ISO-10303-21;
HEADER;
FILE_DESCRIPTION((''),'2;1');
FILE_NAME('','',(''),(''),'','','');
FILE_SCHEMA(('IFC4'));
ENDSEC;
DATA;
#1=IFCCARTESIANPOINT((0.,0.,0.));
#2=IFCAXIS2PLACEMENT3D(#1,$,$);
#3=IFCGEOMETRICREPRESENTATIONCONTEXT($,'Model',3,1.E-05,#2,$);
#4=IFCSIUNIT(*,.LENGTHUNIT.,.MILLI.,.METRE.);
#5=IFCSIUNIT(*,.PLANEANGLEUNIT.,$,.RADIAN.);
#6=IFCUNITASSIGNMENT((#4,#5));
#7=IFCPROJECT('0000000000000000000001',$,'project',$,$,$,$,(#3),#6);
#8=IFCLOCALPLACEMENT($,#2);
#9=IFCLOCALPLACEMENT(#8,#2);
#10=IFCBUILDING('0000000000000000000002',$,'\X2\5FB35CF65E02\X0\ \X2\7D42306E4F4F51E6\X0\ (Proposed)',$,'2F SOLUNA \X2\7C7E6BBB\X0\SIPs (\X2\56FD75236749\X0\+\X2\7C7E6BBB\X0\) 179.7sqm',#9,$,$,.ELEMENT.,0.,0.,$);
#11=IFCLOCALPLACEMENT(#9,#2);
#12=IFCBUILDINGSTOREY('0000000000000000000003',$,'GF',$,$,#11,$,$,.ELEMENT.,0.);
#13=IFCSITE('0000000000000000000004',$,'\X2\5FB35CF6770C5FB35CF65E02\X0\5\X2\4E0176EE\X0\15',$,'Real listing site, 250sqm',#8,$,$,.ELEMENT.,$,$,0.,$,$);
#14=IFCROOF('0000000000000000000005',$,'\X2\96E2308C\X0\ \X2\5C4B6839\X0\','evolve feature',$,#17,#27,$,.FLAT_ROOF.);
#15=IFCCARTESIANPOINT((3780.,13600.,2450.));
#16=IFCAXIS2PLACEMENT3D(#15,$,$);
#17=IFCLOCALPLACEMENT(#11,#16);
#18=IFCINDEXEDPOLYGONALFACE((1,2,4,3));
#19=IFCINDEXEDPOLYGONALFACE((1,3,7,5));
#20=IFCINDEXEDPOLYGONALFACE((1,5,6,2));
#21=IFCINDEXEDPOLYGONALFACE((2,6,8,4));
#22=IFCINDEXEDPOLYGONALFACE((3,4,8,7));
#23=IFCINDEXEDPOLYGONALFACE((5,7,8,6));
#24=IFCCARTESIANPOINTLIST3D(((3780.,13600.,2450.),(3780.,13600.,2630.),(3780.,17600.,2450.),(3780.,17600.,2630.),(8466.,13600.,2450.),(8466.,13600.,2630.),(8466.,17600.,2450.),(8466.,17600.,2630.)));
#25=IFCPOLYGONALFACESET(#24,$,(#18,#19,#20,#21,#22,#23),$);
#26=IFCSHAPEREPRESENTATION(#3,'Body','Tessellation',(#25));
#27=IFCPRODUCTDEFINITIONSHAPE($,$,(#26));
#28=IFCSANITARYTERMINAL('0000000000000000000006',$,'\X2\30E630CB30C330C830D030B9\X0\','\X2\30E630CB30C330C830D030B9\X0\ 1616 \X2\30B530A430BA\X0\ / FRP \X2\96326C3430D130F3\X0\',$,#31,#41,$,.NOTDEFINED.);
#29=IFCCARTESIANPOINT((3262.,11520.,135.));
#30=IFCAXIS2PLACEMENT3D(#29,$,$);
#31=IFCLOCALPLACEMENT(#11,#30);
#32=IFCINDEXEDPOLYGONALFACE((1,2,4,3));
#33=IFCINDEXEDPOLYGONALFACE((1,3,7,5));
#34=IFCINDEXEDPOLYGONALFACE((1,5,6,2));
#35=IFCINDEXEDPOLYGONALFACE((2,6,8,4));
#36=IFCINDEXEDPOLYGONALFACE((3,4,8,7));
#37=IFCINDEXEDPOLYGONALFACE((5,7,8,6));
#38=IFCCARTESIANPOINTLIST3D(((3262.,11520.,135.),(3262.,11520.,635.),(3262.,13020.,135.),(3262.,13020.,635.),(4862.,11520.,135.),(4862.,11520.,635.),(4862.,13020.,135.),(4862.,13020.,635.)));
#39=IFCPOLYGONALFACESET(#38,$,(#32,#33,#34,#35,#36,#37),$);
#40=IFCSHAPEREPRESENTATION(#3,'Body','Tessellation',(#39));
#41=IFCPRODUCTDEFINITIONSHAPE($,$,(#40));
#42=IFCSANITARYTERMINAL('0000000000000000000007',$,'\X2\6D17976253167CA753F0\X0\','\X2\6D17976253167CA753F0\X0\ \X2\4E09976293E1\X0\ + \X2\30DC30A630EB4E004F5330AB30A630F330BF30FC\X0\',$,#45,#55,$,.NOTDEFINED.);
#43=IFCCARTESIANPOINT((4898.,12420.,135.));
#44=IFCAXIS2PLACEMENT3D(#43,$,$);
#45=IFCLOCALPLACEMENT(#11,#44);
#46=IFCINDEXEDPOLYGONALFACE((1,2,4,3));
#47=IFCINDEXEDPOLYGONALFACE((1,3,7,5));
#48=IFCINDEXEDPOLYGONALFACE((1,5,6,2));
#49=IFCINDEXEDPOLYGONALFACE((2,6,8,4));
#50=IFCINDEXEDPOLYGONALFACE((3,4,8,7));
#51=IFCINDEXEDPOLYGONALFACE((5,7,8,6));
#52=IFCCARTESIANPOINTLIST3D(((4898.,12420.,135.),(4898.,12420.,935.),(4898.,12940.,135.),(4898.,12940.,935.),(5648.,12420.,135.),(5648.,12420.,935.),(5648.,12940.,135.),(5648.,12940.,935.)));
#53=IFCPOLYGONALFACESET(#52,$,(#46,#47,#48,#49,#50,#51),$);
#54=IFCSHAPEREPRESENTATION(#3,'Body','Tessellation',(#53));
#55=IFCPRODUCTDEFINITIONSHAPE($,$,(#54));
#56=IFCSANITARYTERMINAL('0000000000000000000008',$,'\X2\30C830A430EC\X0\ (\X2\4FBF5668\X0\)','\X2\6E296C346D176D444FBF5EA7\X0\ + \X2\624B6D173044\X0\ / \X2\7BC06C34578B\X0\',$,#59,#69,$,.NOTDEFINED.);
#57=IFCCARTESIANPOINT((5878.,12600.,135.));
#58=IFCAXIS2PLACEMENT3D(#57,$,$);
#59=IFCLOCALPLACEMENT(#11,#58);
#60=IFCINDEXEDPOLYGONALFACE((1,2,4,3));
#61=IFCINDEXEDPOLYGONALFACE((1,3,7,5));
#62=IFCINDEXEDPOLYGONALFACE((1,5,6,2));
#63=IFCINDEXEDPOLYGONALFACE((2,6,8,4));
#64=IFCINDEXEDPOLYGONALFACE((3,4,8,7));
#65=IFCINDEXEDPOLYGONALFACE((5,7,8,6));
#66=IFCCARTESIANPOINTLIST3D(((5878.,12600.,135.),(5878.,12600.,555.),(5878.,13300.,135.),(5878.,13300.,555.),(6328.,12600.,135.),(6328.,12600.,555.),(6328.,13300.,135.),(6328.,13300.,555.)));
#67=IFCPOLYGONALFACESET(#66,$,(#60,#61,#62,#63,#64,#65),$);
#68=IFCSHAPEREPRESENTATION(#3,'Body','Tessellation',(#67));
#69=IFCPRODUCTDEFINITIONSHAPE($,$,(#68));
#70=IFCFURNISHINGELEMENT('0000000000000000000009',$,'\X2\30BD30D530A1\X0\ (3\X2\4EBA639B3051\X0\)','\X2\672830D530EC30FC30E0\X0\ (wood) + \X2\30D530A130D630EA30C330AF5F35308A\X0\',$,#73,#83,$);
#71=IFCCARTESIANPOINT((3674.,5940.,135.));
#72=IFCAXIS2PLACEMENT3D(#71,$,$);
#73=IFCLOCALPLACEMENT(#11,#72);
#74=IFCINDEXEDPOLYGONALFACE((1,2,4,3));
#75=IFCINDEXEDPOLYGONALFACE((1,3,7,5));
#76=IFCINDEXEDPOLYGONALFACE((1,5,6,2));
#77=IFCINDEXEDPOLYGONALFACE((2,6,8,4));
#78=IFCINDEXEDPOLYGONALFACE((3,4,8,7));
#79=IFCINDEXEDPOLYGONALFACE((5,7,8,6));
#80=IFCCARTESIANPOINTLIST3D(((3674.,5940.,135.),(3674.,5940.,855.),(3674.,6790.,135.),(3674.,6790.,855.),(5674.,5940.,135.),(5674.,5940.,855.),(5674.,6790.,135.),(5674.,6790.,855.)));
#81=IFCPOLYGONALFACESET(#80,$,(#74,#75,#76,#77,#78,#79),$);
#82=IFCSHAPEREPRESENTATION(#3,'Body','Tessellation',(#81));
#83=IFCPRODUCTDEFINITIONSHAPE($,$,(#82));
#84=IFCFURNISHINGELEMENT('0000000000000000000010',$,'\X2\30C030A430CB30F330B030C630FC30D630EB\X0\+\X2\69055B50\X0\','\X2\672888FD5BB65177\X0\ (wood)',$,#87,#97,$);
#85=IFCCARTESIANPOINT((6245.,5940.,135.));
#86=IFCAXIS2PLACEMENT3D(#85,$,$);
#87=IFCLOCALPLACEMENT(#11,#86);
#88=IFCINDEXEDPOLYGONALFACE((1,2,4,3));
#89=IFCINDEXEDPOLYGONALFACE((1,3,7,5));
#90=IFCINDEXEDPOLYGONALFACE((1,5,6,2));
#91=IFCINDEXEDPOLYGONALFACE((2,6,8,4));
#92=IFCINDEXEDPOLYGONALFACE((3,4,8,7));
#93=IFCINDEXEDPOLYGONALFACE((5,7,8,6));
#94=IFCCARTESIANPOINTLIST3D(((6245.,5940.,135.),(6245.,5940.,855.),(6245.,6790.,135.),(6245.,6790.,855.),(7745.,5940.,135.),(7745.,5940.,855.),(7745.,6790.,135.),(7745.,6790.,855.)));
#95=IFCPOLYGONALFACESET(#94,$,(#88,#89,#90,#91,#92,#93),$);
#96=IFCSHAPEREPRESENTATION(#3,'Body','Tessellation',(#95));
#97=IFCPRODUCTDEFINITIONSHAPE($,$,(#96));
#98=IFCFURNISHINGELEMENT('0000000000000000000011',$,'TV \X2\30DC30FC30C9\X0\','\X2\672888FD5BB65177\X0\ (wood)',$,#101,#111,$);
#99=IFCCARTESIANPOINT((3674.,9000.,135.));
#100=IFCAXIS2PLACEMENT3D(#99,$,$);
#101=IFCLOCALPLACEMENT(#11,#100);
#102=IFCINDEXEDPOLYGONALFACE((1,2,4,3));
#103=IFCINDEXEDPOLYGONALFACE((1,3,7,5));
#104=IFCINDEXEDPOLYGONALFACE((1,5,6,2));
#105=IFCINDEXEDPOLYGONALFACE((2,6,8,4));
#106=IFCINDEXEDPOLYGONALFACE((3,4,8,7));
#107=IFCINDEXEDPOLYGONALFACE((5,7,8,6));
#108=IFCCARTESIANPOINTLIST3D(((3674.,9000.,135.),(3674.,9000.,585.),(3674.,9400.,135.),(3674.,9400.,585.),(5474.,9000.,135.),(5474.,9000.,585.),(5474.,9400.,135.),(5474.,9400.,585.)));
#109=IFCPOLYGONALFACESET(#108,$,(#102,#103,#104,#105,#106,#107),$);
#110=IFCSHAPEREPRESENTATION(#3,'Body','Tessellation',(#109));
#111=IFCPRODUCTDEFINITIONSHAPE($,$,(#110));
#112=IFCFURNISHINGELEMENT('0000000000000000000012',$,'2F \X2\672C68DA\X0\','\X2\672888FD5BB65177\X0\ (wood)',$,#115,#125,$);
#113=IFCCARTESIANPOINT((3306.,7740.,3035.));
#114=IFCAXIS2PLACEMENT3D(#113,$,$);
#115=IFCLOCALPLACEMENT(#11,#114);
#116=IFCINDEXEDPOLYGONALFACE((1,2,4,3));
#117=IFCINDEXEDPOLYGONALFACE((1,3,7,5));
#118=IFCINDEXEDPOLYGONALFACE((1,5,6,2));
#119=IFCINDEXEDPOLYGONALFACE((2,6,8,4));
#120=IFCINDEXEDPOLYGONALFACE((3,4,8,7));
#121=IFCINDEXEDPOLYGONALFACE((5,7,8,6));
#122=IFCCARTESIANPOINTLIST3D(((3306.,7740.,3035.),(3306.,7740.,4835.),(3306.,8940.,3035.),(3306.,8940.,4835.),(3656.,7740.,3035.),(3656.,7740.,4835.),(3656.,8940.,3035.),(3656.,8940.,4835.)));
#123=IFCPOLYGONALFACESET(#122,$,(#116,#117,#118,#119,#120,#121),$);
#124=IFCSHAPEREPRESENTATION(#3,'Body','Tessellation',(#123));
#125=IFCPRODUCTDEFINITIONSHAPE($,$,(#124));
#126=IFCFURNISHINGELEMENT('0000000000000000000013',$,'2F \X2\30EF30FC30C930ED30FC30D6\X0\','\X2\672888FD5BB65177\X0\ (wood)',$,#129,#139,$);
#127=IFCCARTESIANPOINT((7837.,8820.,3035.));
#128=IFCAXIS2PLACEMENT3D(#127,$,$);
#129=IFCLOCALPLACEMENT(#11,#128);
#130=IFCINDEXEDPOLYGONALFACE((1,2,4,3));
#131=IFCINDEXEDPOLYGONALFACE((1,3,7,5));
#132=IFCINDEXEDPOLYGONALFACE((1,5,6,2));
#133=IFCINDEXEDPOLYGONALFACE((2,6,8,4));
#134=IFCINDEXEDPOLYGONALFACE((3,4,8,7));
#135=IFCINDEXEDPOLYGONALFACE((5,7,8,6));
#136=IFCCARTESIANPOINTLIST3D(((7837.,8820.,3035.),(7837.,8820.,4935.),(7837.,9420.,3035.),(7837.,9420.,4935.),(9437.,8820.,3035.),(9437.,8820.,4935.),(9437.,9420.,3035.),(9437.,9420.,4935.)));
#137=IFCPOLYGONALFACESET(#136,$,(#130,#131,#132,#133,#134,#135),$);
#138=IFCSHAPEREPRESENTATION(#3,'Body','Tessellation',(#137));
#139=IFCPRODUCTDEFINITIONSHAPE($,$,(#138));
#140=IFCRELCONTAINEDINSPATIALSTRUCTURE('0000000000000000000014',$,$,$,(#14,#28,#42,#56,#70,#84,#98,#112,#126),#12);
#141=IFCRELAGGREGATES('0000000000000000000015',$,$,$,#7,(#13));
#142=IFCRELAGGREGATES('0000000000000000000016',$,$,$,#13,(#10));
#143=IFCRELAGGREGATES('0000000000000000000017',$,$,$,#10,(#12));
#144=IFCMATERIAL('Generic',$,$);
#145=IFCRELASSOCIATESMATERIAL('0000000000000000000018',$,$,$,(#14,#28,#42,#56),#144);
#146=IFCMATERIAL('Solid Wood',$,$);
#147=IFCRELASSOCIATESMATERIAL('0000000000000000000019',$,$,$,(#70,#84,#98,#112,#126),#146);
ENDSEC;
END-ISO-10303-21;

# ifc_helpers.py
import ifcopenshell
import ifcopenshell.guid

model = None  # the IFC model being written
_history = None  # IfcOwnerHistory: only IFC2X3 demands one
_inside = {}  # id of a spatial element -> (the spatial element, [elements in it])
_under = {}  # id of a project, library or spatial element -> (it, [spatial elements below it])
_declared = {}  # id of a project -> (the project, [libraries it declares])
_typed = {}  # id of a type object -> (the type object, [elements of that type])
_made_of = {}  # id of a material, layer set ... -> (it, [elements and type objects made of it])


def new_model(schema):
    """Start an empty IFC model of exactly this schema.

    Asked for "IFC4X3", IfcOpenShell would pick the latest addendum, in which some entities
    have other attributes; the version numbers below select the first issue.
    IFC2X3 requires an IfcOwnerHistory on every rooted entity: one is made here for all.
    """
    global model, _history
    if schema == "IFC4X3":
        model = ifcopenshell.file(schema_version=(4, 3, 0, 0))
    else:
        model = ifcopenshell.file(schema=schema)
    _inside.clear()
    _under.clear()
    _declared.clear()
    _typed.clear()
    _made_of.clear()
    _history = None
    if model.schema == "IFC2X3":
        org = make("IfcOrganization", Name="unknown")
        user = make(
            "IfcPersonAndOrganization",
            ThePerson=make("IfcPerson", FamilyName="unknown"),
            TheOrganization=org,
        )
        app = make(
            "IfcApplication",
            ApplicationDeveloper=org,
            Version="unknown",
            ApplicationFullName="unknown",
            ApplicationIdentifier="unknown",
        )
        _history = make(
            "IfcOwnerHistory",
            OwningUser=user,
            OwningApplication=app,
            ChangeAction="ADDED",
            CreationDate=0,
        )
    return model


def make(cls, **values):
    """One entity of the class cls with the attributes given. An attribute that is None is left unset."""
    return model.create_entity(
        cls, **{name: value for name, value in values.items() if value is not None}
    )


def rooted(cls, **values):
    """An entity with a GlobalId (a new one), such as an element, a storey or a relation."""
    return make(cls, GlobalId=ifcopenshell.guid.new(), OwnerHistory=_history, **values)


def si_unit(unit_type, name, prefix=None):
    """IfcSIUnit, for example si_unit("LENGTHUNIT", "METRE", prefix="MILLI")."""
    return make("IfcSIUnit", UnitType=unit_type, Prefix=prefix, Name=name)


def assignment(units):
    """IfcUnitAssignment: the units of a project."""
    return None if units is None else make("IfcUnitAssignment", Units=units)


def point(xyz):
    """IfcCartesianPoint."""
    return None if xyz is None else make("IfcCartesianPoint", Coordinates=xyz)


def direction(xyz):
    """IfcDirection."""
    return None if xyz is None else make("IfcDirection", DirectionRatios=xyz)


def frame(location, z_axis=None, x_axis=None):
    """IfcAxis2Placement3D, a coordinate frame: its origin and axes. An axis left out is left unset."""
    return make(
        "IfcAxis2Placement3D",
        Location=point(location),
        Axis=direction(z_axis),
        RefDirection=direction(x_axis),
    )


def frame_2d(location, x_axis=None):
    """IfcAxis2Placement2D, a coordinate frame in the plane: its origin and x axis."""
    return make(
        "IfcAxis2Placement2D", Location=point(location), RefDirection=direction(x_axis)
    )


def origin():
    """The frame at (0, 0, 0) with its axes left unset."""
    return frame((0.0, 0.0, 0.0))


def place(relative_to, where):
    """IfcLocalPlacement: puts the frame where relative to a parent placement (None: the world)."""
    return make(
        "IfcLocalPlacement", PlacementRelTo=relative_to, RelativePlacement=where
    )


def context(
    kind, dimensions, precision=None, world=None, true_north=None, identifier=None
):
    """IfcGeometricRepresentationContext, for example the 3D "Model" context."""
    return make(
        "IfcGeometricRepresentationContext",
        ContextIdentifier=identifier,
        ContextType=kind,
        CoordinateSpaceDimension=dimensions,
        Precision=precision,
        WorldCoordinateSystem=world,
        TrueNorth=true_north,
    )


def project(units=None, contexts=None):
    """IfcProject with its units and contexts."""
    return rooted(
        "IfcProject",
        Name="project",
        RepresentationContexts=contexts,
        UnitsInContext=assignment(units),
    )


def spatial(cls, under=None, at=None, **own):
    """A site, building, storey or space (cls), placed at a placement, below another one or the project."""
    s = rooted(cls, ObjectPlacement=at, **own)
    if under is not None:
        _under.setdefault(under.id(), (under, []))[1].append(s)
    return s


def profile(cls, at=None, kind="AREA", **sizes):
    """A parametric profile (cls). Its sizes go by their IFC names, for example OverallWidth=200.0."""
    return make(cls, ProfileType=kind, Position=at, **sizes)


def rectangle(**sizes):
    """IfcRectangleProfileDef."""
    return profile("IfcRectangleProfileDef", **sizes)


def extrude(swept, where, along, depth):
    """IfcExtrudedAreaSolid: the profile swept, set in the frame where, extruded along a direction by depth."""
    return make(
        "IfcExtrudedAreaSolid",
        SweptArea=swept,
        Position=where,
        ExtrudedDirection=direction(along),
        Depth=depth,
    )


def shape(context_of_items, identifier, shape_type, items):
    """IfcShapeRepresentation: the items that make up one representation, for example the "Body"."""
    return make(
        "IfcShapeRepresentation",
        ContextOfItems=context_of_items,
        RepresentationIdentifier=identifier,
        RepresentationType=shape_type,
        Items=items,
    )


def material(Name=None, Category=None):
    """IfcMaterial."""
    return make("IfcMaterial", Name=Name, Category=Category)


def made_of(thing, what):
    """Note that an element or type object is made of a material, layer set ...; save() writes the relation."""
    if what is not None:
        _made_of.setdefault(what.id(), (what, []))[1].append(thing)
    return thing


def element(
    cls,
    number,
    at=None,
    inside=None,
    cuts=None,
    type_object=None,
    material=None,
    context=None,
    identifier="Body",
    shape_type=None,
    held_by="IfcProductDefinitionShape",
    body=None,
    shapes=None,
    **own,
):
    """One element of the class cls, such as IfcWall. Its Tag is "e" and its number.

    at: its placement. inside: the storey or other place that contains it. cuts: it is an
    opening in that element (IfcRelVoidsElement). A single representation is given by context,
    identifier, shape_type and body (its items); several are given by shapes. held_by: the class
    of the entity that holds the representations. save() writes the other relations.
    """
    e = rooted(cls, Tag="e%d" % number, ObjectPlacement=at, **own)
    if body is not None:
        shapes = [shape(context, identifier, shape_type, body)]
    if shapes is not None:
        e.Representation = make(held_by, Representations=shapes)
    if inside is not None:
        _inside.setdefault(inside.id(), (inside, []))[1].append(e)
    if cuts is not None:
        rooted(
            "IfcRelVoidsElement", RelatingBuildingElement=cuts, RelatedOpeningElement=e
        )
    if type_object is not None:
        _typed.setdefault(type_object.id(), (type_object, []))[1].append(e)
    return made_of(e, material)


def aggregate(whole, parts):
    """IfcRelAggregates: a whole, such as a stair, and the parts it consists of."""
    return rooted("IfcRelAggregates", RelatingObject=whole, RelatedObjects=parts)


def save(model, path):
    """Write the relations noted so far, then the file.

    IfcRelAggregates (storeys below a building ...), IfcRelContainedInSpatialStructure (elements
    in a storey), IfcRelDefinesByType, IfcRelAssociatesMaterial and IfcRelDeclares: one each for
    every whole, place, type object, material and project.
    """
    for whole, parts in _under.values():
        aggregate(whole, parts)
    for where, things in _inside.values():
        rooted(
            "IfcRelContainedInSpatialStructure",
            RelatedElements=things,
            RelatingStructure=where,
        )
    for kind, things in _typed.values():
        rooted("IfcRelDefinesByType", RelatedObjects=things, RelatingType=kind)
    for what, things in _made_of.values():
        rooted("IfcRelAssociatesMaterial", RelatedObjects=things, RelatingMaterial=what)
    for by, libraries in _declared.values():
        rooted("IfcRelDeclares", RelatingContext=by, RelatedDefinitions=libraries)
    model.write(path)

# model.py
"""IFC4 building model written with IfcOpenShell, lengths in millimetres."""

from ifc_helpers import new_model, si_unit, frame, frame_2d, origin, place, context, project, spatial, rectangle, extrude, material, element, save


model = new_model("IFC4")

# Units and contexts
model_context = context("Model", 3, precision=1e-05, world=origin())
ifc_project = project(units=[si_unit("LENGTHUNIT", "METRE", prefix="MILLI"), si_unit("PLANEANGLEUNIT", "RADIAN")], contexts=[model_context])

# Site, building, storey
site_placement = place(None, origin())
site = spatial("IfcSite", under=ifc_project, at=site_placement, Name="徳島県徳島市5丁目15", ObjectType="Real listing site, 250sqm", CompositionType="ELEMENT", RefElevation=0.0)
building_placement = place(site_placement, origin())
building = spatial("IfcBuilding", under=site, at=building_placement, Name="徳島市 終の住処 (Proposed)", ObjectType="2F SOLUNA 籾殻SIPs (国産杉+籾殻) 179.7sqm", CompositionType="ELEMENT", ElevationOfRefHeight=0.0, ElevationOfTerrain=0.0)
storey_placement = place(building_placement, origin())
storey = spatial("IfcBuildingStorey", under=building, at=storey_placement, Name="GF", CompositionType="ELEMENT", Elevation=0.0)

# Shared definitions
ifc_material_1 = material(Name="Generic")

# Shared definitions
ifc_material_2 = material(Name="Solid Wood")

# Roof
roof_1_placement = place(storey_placement, frame((3780.0, 13600.0, 2450.0)))
element("IfcRoof", 1, at=roof_1_placement, inside=storey, material=ifc_material_1, Name="離れ 屋根", Description="evolve feature", PredefinedType="FLAT_ROOF", context=model_context, shape_type="SweptSolid", body=[
    extrude(rectangle(XDim=4686.0, YDim=4000.0, at=frame_2d((2343.0, 2000.0))), frame((3780.0, 13600.0, 2450.0)), (0.0, 0.0, 1.0), 180.0),
])

# Sanitary terminals
sanitary_terminal_1_placement = place(storey_placement, frame((3262.0, 11520.0, 135.0)))
element("IfcSanitaryTerminal", 2, at=sanitary_terminal_1_placement, inside=storey, material=ifc_material_1, Name="ユニットバス", Description="ユニットバス 1616 サイズ / FRP 防水パン", PredefinedType="NOTDEFINED", context=model_context, shape_type="SweptSolid", body=[
    extrude(rectangle(XDim=1600.0, YDim=1500.0, at=frame_2d((800.0, 750.0))), frame((3262.0, 11520.0, 135.0)), (0.0, 0.0, 1.0), 500.0),
])
sanitary_terminal_2_placement = place(storey_placement, frame((4898.0, 12420.0, 135.0)))
element("IfcSanitaryTerminal", 3, at=sanitary_terminal_2_placement, inside=storey, material=ifc_material_1, Name="洗面化粧台", Description="洗面化粧台 三面鏡 + ボウル一体カウンター", PredefinedType="NOTDEFINED", context=model_context, shape_type="SweptSolid", body=[
    extrude(rectangle(XDim=750.0, YDim=520.0, at=frame_2d((375.0, 260.0))), frame((4898.0, 12420.0, 135.0)), (0.0, 0.0, 1.0), 800.0),
])
sanitary_terminal_3_placement = place(storey_placement, frame((5878.0, 12600.0, 135.0)))
element("IfcSanitaryTerminal", 4, at=sanitary_terminal_3_placement, inside=storey, material=ifc_material_1, Name="トイレ (便器)", Description="温水洗浄便座 + 手洗い / 節水型", PredefinedType="NOTDEFINED", context=model_context, shape_type="SweptSolid", body=[
    extrude(rectangle(XDim=450.0, YDim=700.0, at=frame_2d((225.0, 350.0))), frame((5878.0, 12600.0, 135.0)), (0.0, 0.0, 1.0), 420.0),
])

# Furnishing elements
furnishing_1_placement = place(storey_placement, frame((3674.0, 5940.0, 135.0)))
element("IfcFurnishingElement", 5, at=furnishing_1_placement, inside=storey, material=ifc_material_2, Name="ソファ (3人掛け)", Description="木フレーム (wood) + ファブリック張り", context=model_context, shape_type="SweptSolid", body=[
    extrude(rectangle(XDim=2000.0, YDim=850.0, at=frame_2d((1000.0, 425.0))), frame((3674.0, 5940.0, 135.0)), (0.0, 0.0, 1.0), 720.0),
])
furnishing_2_placement = place(storey_placement, frame((6245.0, 5940.0, 135.0)))
element("IfcFurnishingElement", 6, at=furnishing_2_placement, inside=storey, material=ifc_material_2, Name="ダイニングテーブル+椅子", Description="木製家具 (wood)", context=model_context, shape_type="SweptSolid", body=[
    extrude(rectangle(XDim=1500.0, YDim=850.0, at=frame_2d((750.0, 425.0))), frame((6245.0, 5940.0, 135.0)), (0.0, 0.0, 1.0), 720.0),
])
furnishing_3_placement = place(storey_placement, frame((3674.0, 9000.0, 135.0)))
element("IfcFurnishingElement", 7, at=furnishing_3_placement, inside=storey, material=ifc_material_2, Name="TV ボード", Description="木製家具 (wood)", context=model_context, shape_type="SweptSolid", body=[
    extrude(rectangle(XDim=1800.0, YDim=400.0, at=frame_2d((900.0, 200.0))), frame((3674.0, 9000.0, 135.0)), (0.0, 0.0, 1.0), 450.0),
])
furnishing_4_placement = place(storey_placement, frame((3306.0, 7740.0, 3035.0)))
element("IfcFurnishingElement", 8, at=furnishing_4_placement, inside=storey, material=ifc_material_2, Name="2F 本棚", Description="木製家具 (wood)", context=model_context, shape_type="SweptSolid", body=[
    extrude(rectangle(XDim=350.0, YDim=1200.0, at=frame_2d((175.0, 600.0))), frame((3306.0, 7740.0, 3035.0)), (0.0, 0.0, 1.0), 1800.0),
])
furnishing_5_placement = place(storey_placement, frame((7837.0, 8820.0, 3035.0)))
element("IfcFurnishingElement", 9, at=furnishing_5_placement, inside=storey, material=ifc_material_2, Name="2F ワードローブ", Description="木製家具 (wood)", context=model_context, shape_type="SweptSolid", body=[
    extrude(rectangle(XDim=1600.0, YDim=600.0, at=frame_2d((800.0, 300.0))), frame((7837.0, 8820.0, 3035.0)), (0.0, 0.0, 1.0), 1900.0),
])

save(model, "model.ifc")
